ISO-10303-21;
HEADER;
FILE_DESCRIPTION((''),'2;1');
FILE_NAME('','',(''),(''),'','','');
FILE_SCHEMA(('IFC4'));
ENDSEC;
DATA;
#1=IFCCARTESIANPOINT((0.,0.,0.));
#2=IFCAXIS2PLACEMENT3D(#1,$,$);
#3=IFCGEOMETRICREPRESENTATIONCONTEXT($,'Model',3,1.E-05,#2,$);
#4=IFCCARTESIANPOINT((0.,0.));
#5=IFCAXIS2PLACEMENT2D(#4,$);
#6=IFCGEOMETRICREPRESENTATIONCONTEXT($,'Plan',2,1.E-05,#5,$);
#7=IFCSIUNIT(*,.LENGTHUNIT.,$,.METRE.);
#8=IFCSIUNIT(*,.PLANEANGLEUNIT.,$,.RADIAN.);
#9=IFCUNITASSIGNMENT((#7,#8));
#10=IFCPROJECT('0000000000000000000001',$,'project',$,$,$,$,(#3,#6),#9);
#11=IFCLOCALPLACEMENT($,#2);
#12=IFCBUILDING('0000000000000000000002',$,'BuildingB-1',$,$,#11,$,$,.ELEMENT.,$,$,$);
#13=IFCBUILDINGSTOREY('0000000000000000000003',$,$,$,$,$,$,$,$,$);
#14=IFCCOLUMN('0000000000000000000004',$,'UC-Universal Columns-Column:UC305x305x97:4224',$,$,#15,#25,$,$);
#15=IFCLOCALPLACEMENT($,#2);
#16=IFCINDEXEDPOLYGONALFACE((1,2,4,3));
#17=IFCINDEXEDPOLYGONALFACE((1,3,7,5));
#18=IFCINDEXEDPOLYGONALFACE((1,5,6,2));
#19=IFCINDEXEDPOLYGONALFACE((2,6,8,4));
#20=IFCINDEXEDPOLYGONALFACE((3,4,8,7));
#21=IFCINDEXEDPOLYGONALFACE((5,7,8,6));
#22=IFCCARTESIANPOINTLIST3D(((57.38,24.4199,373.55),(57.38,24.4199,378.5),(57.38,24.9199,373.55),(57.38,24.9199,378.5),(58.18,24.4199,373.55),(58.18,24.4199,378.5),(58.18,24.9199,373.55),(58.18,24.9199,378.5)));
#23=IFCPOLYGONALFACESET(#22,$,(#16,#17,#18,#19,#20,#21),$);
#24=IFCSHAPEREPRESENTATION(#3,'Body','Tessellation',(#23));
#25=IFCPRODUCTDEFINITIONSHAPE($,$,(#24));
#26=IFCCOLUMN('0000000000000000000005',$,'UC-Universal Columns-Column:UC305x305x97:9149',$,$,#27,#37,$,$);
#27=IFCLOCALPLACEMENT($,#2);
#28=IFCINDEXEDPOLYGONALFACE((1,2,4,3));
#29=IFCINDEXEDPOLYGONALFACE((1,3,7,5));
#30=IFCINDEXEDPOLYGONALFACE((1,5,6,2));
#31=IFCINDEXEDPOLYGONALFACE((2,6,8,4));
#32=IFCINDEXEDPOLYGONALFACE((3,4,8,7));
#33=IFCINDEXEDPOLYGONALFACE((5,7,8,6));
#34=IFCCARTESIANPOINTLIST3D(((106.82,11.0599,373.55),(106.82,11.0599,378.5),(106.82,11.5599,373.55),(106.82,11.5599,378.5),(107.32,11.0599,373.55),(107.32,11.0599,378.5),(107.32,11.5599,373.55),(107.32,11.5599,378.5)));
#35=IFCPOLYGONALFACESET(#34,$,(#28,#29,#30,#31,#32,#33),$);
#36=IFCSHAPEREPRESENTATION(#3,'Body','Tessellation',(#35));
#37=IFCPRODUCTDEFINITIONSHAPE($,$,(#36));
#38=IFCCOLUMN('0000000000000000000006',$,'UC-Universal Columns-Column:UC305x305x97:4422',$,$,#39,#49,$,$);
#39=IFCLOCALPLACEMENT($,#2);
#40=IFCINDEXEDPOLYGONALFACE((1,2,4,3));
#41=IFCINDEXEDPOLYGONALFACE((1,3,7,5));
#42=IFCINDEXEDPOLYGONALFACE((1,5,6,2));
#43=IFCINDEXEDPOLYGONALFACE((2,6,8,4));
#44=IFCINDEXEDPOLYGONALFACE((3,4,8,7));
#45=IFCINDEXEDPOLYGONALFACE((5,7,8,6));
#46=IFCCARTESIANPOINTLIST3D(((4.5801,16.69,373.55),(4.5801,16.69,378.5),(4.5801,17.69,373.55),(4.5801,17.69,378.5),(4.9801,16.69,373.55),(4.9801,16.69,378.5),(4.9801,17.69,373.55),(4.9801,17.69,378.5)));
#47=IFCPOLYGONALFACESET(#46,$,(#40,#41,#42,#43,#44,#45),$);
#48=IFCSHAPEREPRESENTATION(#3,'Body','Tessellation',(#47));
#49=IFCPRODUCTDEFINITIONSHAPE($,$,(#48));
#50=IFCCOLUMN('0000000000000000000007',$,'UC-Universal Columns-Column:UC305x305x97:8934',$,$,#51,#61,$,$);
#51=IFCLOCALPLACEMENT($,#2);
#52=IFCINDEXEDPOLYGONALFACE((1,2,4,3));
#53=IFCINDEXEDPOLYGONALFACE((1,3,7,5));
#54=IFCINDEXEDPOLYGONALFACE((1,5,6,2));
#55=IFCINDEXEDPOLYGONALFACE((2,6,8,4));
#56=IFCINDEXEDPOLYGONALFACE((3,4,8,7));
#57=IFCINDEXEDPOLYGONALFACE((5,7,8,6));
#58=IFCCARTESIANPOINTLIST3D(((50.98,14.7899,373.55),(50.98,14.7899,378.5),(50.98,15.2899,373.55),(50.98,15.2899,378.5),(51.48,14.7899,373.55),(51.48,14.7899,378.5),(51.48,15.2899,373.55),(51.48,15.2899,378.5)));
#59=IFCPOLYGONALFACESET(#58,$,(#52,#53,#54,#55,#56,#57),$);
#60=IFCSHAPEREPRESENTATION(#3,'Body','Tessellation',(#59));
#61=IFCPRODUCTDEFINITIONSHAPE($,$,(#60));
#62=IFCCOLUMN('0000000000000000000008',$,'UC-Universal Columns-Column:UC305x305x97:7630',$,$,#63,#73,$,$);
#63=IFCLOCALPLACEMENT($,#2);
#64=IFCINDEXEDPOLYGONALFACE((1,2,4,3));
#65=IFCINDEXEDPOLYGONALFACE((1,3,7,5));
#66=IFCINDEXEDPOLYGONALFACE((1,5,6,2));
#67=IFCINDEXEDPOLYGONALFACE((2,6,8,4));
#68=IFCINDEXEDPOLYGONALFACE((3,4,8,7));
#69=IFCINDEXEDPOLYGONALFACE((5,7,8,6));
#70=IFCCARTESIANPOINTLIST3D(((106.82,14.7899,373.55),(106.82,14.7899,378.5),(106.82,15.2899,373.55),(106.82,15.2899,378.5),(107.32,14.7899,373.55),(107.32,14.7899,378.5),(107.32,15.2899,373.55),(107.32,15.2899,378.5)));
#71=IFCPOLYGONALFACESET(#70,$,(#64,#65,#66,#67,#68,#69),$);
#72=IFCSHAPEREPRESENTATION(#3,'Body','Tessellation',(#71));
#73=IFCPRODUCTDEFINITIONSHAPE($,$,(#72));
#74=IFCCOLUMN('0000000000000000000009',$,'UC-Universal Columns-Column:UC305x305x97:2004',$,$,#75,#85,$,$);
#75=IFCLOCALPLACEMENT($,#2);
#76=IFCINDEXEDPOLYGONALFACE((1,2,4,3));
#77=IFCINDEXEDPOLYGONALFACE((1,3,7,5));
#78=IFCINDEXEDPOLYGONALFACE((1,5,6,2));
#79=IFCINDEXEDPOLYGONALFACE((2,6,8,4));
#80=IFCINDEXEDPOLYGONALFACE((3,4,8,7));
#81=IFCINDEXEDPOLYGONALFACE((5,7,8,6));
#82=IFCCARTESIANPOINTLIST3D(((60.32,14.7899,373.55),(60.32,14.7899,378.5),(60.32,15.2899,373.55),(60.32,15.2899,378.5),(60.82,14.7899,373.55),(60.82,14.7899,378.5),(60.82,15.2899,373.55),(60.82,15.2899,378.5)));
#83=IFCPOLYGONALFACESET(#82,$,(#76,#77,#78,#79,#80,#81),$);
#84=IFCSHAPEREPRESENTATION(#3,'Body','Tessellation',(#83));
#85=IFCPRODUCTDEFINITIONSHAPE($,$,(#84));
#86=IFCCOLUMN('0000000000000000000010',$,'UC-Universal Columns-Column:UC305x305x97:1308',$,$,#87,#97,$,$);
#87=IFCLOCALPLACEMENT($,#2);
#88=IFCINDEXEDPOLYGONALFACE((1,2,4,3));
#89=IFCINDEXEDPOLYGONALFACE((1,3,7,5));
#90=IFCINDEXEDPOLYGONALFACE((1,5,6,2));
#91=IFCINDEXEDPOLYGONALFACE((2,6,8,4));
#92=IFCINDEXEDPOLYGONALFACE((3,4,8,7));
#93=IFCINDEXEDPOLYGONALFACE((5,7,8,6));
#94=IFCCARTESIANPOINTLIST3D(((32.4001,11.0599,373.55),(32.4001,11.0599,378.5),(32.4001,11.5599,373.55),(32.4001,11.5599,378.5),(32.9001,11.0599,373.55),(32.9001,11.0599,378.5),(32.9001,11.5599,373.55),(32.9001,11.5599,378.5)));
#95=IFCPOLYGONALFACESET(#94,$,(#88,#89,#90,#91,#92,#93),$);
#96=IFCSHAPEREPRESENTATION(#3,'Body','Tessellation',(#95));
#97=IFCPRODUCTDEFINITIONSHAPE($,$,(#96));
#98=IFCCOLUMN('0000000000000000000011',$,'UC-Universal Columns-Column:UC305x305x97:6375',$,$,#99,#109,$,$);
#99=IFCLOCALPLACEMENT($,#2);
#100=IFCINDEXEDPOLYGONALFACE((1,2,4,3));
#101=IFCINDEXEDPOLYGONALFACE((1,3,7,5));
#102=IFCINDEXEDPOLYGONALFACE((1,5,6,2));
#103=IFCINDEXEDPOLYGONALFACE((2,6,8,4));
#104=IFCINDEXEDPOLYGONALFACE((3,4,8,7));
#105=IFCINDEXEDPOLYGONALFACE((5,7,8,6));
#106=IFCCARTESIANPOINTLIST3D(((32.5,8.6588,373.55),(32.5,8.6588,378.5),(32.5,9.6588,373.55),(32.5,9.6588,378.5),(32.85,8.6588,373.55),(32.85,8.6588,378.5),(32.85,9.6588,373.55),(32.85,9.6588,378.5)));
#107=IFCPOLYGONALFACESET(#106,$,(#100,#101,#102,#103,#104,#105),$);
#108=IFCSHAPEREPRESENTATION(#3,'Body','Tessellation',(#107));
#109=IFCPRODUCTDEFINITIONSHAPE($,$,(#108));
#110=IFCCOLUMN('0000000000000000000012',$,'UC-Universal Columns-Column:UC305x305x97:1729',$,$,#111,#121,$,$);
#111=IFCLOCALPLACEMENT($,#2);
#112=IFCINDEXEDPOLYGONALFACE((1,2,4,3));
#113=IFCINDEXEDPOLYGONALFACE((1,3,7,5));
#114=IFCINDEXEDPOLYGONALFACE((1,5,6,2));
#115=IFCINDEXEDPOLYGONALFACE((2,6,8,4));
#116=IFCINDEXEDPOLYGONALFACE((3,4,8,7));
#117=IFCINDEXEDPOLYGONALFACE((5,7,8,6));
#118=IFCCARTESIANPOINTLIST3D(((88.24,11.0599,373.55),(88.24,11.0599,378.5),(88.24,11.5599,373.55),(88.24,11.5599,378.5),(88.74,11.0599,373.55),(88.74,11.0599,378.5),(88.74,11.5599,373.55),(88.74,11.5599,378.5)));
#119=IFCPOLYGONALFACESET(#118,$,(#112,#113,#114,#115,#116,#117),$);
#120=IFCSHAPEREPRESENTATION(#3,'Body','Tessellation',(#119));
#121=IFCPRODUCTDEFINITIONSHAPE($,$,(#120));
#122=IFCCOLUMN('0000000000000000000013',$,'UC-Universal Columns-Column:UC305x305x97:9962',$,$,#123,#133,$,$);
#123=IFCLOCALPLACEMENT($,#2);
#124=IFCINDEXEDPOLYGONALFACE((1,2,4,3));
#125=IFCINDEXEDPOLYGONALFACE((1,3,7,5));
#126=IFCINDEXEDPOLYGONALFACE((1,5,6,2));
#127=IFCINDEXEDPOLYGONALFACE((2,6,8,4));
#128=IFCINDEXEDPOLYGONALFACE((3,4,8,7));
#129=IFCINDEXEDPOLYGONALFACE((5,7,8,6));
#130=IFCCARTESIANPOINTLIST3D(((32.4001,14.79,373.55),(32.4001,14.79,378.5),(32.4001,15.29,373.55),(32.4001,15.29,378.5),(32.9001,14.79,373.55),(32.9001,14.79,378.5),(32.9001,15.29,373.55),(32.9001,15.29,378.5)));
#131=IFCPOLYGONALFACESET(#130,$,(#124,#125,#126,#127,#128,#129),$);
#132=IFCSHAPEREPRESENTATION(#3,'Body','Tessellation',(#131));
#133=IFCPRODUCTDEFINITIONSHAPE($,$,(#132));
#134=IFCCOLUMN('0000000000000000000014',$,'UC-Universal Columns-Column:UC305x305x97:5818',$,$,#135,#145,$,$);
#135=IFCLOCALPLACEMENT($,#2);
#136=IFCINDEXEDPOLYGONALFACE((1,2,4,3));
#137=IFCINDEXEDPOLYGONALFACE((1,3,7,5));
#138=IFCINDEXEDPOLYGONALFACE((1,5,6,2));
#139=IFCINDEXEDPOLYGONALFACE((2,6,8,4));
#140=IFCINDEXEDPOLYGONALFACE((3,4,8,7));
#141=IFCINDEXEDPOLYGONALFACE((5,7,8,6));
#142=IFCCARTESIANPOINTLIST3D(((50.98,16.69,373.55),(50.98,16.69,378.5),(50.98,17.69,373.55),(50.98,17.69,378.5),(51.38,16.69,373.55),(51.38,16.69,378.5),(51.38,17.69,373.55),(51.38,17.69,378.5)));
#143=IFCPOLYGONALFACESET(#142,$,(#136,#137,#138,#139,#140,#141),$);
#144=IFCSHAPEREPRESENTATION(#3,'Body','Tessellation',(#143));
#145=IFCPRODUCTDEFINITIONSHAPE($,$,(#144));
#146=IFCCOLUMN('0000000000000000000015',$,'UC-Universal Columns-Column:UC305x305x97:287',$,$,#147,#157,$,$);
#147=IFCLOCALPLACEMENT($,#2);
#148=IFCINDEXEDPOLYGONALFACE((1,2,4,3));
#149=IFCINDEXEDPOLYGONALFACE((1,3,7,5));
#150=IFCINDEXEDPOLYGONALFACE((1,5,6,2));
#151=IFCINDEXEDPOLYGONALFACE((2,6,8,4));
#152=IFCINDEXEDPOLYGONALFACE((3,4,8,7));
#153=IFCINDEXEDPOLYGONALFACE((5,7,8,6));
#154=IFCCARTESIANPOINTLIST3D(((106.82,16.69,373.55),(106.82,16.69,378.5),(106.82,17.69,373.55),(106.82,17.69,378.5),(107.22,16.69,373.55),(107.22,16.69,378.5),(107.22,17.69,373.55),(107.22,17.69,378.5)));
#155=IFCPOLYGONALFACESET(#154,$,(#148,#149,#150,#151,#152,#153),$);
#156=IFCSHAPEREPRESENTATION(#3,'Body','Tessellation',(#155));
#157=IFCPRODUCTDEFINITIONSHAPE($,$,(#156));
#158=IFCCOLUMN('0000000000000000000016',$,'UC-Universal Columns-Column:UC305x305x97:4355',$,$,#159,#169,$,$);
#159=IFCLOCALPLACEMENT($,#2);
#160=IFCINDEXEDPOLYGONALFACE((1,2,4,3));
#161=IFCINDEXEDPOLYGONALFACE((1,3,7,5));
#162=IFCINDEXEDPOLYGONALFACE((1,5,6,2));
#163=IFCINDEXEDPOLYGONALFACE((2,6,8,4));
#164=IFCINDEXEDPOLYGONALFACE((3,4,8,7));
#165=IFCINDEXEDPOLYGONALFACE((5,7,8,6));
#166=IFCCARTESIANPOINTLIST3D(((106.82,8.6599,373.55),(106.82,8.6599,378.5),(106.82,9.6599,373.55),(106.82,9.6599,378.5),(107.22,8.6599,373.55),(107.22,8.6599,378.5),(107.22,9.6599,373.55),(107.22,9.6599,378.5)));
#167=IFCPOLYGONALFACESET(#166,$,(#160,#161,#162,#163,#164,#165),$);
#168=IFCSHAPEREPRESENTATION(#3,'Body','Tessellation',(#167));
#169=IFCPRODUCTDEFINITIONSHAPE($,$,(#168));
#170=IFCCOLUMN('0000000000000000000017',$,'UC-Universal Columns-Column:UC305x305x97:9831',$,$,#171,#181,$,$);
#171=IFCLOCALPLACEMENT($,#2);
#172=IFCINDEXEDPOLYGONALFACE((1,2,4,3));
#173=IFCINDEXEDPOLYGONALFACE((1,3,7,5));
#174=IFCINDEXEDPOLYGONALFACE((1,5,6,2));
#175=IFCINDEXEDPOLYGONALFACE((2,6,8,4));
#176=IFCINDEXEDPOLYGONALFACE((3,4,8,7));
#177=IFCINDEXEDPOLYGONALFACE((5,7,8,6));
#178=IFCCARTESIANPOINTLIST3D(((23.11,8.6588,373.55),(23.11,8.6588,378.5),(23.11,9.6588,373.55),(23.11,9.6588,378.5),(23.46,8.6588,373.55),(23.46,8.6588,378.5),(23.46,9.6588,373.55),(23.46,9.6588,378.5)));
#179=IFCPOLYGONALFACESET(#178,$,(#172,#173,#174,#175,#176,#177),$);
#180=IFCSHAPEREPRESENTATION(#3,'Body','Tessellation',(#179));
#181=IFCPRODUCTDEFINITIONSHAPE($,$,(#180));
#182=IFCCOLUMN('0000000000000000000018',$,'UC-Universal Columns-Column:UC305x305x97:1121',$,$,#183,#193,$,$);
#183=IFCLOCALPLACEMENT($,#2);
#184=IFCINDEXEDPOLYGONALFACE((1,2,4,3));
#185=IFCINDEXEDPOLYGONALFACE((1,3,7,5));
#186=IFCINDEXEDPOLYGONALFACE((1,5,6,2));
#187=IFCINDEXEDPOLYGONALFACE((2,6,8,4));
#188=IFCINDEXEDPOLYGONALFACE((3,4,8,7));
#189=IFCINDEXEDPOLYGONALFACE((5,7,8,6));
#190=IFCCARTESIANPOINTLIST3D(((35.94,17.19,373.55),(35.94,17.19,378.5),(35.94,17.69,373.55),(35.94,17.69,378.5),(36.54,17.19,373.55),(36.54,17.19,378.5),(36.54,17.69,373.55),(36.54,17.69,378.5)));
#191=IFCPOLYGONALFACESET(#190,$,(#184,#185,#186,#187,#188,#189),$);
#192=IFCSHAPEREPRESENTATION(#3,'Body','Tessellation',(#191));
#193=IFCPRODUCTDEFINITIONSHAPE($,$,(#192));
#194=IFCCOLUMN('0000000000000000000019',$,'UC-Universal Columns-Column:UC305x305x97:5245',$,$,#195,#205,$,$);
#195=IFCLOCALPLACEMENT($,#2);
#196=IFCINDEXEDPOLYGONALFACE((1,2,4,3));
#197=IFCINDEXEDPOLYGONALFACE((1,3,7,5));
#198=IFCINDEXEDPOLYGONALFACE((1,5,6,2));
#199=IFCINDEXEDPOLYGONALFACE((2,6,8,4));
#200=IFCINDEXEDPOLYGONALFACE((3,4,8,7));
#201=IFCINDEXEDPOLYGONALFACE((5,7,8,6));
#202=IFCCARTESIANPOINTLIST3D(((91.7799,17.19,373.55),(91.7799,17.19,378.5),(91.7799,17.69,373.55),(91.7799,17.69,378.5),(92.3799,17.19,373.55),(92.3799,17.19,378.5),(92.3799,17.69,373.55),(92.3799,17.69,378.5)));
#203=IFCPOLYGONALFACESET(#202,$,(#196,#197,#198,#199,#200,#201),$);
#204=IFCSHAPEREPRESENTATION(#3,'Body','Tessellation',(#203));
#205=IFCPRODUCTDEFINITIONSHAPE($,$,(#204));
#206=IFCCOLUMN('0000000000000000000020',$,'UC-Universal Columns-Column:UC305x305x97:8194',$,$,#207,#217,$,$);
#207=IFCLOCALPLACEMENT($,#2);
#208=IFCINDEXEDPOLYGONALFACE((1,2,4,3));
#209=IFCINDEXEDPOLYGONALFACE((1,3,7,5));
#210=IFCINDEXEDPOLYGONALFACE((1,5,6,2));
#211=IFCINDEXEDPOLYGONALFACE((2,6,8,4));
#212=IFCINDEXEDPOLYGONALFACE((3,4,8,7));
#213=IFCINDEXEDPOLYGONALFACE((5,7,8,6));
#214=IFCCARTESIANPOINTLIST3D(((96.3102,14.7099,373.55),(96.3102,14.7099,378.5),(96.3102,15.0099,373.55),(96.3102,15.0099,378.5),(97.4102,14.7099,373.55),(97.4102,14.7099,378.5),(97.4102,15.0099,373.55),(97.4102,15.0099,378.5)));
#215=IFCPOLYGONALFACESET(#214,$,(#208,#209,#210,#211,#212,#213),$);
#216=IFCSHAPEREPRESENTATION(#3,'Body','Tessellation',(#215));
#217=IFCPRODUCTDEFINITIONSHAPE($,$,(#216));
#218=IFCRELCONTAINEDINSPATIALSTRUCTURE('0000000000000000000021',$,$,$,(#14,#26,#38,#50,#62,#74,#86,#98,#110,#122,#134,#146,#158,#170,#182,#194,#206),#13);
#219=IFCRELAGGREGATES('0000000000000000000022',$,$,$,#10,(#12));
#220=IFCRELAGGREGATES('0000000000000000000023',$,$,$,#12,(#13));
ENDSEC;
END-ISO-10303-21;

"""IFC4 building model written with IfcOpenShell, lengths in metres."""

from ifc_helpers import new_model, si_unit, origin, origin_2d, place, context, project, spatial, polyline, outline, extrude, element, save


model = new_model("IFC4")

# Units and contexts
model_context = context("Model", 3, precision=1e-05, world=origin())
plan_context = context("Plan", 2, precision=1e-05, world=origin_2d())
ifc_project = project(units=[si_unit("LENGTHUNIT", "METRE"), si_unit("PLANEANGLEUNIT", "RADIAN")], contexts=[model_context, plan_context])

# Building, storey
building_placement = place(None, origin())
building = spatial("IfcBuilding", under=ifc_project, at=building_placement, Name="BuildingB-1", CompositionType="ELEMENT")
storey = spatial("IfcBuildingStorey", under=building)

# Columns
element("IfcColumn", 1, inside=storey, Name="UC-Universal Columns-Column:UC305x305x97:4224", context=model_context, shape_type="SweptSolid", body=[
    extrude(outline(polyline([(57.38, 24.4199, 378.5), (58.18, 24.4199, 378.5), (58.18, 24.9199, 378.5), (57.38, 24.9199, 378.5), (57.38, 24.4199, 378.5)])), None, (0.0, 0.0, -1.0), 4.95),
])
element("IfcColumn", 2, inside=storey, Name="UC-Universal Columns-Column:UC305x305x97:9149", context=model_context, shape_type="SweptSolid", body=[
    extrude(outline(polyline([(106.82, 11.0599, 378.5), (107.32, 11.0599, 378.5), (107.32, 11.5599, 378.5), (106.82, 11.5599, 378.5), (106.82, 11.0599, 378.5)])), None, (0.0, 0.0, -1.0), 4.95),
])
element("IfcColumn", 3, inside=storey, Name="UC-Universal Columns-Column:UC305x305x97:4422", context=model_context, shape_type="SweptSolid", body=[
    extrude(outline(polyline([(4.5801, 17.69, 378.5), (4.9801, 17.69, 378.5), (4.9801, 16.69, 378.5), (4.5801, 16.69, 378.5), (4.5801, 17.69, 378.5)])), None, (0.0, 0.0, -1.0), 4.95),
])
element("IfcColumn", 4, inside=storey, Name="UC-Universal Columns-Column:UC305x305x97:8934", context=model_context, shape_type="SweptSolid", body=[
    extrude(outline(polyline([(50.98, 15.2899, 378.5), (51.48, 15.2899, 378.5), (51.48, 14.7899, 378.5), (50.98, 14.7899, 378.5), (50.98, 15.2899, 378.5)])), None, (0.0, 0.0, -1.0), 4.95),
])
element("IfcColumn", 5, inside=storey, Name="UC-Universal Columns-Column:UC305x305x97:7630", context=model_context, shape_type="SweptSolid", body=[
    extrude(outline(polyline([(106.82, 15.2899, 378.5), (107.32, 15.2899, 378.5), (107.32, 14.7899, 378.5), (106.82, 14.7899, 378.5), (106.82, 15.2899, 378.5)])), None, (0.0, 0.0, -1.0), 4.95),
])
element("IfcColumn", 6, inside=storey, Name="UC-Universal Columns-Column:UC305x305x97:2004", context=model_context, shape_type="SweptSolid", body=[
    extrude(outline(polyline([(60.82, 15.2899, 378.5), (60.32, 15.2899, 378.5), (60.32, 14.7899, 378.5), (60.82, 14.7899, 378.5), (60.82, 15.2899, 378.5)])), None, (0.0, 0.0, -1.0), 4.95),
])
element("IfcColumn", 7, inside=storey, Name="UC-Universal Columns-Column:UC305x305x97:1308", context=model_context, shape_type="SweptSolid", body=[
    extrude(outline(polyline([(32.9001, 11.0599, 378.5), (32.4001, 11.0599, 378.5), (32.4001, 11.5599, 378.5), (32.9001, 11.5599, 378.5), (32.9001, 11.0599, 378.5)])), None, (0.0, 0.0, -1.0), 4.95),
])
element("IfcColumn", 8, inside=storey, Name="UC-Universal Columns-Column:UC305x305x97:6375", context=model_context, shape_type="SweptSolid", body=[
    extrude(outline(polyline([(32.5, 8.6588, 378.5), (32.85, 8.6588, 378.5), (32.85, 9.6588, 378.5), (32.5, 9.6588, 378.5), (32.5, 8.6588, 378.5)])), None, (0.0, 0.0, -1.0), 4.95),
])
element("IfcColumn", 9, inside=storey, Name="UC-Universal Columns-Column:UC305x305x97:1729", context=model_context, shape_type="SweptSolid", body=[
    extrude(outline(polyline([(88.74, 11.0599, 378.5), (88.24, 11.0599, 378.5), (88.24, 11.5599, 378.5), (88.74, 11.5599, 378.5), (88.74, 11.0599, 378.5)])), None, (0.0, 0.0, -1.0), 4.95),
])
element("IfcColumn", 10, inside=storey, Name="UC-Universal Columns-Column:UC305x305x97:9962", context=model_context, shape_type="SweptSolid", body=[
    extrude(outline(polyline([(32.9001, 15.29, 378.5), (32.4001, 15.29, 378.5), (32.4001, 14.79, 378.5), (32.9001, 14.79, 378.5), (32.9001, 15.29, 378.5)])), None, (0.0, 0.0, -1.0), 4.95),
])
element("IfcColumn", 11, inside=storey, Name="UC-Universal Columns-Column:UC305x305x97:5818", context=model_context, shape_type="SweptSolid", body=[
    extrude(outline(polyline([(51.38, 17.69, 378.5), (50.98, 17.69, 378.5), (50.98, 16.69, 378.5), (51.38, 16.69, 378.5), (51.38, 17.69, 378.5)])), None, (0.0, 0.0, -1.0), 4.95),
])
element("IfcColumn", 12, inside=storey, Name="UC-Universal Columns-Column:UC305x305x97:287", context=model_context, shape_type="SweptSolid", body=[
    extrude(outline(polyline([(107.22, 17.69, 378.5), (106.82, 17.69, 378.5), (106.82, 16.69, 378.5), (107.22, 16.69, 378.5), (107.22, 17.69, 378.5)])), None, (0.0, 0.0, -1.0), 4.95),
])
element("IfcColumn", 13, inside=storey, Name="UC-Universal Columns-Column:UC305x305x97:4355", context=model_context, shape_type="SweptSolid", body=[
    extrude(outline(polyline([(107.22, 8.6599, 378.5), (106.82, 8.6599, 378.5), (106.82, 9.6599, 378.5), (107.22, 9.6599, 378.5), (107.22, 8.6599, 378.5)])), None, (0.0, 0.0, -1.0), 4.95),
])
element("IfcColumn", 14, inside=storey, Name="UC-Universal Columns-Column:UC305x305x97:9831", context=model_context, shape_type="SweptSolid", body=[
    extrude(outline(polyline([(23.46, 8.6588, 378.5), (23.11, 8.6588, 378.5), (23.11, 9.6588, 378.5), (23.46, 9.6588, 378.5), (23.46, 8.6588, 378.5)])), None, (0.0, 0.0, -1.0), 4.95),
])
element("IfcColumn", 15, inside=storey, Name="UC-Universal Columns-Column:UC305x305x97:1121", context=model_context, shape_type="SweptSolid", body=[
    extrude(outline(polyline([(36.54, 17.69, 378.5), (35.94, 17.69, 378.5), (35.94, 17.19, 378.5), (36.54, 17.19, 378.5), (36.54, 17.69, 378.5)])), None, (0.0, 0.0, -1.0), 4.95),
])
element("IfcColumn", 16, inside=storey, Name="UC-Universal Columns-Column:UC305x305x97:5245", context=model_context, shape_type="SweptSolid", body=[
    extrude(outline(polyline([(92.3799, 17.69, 378.5), (91.7799, 17.69, 378.5), (91.7799, 17.19, 378.5), (92.3799, 17.19, 378.5), (92.3799, 17.69, 378.5)])), None, (0.0, 0.0, -1.0), 4.95),
])
element("IfcColumn", 17, inside=storey, Name="UC-Universal Columns-Column:UC305x305x97:8194", context=model_context, shape_type="SweptSolid", body=[
    extrude(outline(polyline([(97.4102, 15.0099, 378.5), (96.3102, 15.0099, 378.5), (96.3102, 14.7099, 378.5), (97.4102, 14.7099, 378.5), (97.4102, 15.0099, 378.5)])), None, (0.0, 0.0, -1.0), 4.95),
])

save(model, "model.ifc")
